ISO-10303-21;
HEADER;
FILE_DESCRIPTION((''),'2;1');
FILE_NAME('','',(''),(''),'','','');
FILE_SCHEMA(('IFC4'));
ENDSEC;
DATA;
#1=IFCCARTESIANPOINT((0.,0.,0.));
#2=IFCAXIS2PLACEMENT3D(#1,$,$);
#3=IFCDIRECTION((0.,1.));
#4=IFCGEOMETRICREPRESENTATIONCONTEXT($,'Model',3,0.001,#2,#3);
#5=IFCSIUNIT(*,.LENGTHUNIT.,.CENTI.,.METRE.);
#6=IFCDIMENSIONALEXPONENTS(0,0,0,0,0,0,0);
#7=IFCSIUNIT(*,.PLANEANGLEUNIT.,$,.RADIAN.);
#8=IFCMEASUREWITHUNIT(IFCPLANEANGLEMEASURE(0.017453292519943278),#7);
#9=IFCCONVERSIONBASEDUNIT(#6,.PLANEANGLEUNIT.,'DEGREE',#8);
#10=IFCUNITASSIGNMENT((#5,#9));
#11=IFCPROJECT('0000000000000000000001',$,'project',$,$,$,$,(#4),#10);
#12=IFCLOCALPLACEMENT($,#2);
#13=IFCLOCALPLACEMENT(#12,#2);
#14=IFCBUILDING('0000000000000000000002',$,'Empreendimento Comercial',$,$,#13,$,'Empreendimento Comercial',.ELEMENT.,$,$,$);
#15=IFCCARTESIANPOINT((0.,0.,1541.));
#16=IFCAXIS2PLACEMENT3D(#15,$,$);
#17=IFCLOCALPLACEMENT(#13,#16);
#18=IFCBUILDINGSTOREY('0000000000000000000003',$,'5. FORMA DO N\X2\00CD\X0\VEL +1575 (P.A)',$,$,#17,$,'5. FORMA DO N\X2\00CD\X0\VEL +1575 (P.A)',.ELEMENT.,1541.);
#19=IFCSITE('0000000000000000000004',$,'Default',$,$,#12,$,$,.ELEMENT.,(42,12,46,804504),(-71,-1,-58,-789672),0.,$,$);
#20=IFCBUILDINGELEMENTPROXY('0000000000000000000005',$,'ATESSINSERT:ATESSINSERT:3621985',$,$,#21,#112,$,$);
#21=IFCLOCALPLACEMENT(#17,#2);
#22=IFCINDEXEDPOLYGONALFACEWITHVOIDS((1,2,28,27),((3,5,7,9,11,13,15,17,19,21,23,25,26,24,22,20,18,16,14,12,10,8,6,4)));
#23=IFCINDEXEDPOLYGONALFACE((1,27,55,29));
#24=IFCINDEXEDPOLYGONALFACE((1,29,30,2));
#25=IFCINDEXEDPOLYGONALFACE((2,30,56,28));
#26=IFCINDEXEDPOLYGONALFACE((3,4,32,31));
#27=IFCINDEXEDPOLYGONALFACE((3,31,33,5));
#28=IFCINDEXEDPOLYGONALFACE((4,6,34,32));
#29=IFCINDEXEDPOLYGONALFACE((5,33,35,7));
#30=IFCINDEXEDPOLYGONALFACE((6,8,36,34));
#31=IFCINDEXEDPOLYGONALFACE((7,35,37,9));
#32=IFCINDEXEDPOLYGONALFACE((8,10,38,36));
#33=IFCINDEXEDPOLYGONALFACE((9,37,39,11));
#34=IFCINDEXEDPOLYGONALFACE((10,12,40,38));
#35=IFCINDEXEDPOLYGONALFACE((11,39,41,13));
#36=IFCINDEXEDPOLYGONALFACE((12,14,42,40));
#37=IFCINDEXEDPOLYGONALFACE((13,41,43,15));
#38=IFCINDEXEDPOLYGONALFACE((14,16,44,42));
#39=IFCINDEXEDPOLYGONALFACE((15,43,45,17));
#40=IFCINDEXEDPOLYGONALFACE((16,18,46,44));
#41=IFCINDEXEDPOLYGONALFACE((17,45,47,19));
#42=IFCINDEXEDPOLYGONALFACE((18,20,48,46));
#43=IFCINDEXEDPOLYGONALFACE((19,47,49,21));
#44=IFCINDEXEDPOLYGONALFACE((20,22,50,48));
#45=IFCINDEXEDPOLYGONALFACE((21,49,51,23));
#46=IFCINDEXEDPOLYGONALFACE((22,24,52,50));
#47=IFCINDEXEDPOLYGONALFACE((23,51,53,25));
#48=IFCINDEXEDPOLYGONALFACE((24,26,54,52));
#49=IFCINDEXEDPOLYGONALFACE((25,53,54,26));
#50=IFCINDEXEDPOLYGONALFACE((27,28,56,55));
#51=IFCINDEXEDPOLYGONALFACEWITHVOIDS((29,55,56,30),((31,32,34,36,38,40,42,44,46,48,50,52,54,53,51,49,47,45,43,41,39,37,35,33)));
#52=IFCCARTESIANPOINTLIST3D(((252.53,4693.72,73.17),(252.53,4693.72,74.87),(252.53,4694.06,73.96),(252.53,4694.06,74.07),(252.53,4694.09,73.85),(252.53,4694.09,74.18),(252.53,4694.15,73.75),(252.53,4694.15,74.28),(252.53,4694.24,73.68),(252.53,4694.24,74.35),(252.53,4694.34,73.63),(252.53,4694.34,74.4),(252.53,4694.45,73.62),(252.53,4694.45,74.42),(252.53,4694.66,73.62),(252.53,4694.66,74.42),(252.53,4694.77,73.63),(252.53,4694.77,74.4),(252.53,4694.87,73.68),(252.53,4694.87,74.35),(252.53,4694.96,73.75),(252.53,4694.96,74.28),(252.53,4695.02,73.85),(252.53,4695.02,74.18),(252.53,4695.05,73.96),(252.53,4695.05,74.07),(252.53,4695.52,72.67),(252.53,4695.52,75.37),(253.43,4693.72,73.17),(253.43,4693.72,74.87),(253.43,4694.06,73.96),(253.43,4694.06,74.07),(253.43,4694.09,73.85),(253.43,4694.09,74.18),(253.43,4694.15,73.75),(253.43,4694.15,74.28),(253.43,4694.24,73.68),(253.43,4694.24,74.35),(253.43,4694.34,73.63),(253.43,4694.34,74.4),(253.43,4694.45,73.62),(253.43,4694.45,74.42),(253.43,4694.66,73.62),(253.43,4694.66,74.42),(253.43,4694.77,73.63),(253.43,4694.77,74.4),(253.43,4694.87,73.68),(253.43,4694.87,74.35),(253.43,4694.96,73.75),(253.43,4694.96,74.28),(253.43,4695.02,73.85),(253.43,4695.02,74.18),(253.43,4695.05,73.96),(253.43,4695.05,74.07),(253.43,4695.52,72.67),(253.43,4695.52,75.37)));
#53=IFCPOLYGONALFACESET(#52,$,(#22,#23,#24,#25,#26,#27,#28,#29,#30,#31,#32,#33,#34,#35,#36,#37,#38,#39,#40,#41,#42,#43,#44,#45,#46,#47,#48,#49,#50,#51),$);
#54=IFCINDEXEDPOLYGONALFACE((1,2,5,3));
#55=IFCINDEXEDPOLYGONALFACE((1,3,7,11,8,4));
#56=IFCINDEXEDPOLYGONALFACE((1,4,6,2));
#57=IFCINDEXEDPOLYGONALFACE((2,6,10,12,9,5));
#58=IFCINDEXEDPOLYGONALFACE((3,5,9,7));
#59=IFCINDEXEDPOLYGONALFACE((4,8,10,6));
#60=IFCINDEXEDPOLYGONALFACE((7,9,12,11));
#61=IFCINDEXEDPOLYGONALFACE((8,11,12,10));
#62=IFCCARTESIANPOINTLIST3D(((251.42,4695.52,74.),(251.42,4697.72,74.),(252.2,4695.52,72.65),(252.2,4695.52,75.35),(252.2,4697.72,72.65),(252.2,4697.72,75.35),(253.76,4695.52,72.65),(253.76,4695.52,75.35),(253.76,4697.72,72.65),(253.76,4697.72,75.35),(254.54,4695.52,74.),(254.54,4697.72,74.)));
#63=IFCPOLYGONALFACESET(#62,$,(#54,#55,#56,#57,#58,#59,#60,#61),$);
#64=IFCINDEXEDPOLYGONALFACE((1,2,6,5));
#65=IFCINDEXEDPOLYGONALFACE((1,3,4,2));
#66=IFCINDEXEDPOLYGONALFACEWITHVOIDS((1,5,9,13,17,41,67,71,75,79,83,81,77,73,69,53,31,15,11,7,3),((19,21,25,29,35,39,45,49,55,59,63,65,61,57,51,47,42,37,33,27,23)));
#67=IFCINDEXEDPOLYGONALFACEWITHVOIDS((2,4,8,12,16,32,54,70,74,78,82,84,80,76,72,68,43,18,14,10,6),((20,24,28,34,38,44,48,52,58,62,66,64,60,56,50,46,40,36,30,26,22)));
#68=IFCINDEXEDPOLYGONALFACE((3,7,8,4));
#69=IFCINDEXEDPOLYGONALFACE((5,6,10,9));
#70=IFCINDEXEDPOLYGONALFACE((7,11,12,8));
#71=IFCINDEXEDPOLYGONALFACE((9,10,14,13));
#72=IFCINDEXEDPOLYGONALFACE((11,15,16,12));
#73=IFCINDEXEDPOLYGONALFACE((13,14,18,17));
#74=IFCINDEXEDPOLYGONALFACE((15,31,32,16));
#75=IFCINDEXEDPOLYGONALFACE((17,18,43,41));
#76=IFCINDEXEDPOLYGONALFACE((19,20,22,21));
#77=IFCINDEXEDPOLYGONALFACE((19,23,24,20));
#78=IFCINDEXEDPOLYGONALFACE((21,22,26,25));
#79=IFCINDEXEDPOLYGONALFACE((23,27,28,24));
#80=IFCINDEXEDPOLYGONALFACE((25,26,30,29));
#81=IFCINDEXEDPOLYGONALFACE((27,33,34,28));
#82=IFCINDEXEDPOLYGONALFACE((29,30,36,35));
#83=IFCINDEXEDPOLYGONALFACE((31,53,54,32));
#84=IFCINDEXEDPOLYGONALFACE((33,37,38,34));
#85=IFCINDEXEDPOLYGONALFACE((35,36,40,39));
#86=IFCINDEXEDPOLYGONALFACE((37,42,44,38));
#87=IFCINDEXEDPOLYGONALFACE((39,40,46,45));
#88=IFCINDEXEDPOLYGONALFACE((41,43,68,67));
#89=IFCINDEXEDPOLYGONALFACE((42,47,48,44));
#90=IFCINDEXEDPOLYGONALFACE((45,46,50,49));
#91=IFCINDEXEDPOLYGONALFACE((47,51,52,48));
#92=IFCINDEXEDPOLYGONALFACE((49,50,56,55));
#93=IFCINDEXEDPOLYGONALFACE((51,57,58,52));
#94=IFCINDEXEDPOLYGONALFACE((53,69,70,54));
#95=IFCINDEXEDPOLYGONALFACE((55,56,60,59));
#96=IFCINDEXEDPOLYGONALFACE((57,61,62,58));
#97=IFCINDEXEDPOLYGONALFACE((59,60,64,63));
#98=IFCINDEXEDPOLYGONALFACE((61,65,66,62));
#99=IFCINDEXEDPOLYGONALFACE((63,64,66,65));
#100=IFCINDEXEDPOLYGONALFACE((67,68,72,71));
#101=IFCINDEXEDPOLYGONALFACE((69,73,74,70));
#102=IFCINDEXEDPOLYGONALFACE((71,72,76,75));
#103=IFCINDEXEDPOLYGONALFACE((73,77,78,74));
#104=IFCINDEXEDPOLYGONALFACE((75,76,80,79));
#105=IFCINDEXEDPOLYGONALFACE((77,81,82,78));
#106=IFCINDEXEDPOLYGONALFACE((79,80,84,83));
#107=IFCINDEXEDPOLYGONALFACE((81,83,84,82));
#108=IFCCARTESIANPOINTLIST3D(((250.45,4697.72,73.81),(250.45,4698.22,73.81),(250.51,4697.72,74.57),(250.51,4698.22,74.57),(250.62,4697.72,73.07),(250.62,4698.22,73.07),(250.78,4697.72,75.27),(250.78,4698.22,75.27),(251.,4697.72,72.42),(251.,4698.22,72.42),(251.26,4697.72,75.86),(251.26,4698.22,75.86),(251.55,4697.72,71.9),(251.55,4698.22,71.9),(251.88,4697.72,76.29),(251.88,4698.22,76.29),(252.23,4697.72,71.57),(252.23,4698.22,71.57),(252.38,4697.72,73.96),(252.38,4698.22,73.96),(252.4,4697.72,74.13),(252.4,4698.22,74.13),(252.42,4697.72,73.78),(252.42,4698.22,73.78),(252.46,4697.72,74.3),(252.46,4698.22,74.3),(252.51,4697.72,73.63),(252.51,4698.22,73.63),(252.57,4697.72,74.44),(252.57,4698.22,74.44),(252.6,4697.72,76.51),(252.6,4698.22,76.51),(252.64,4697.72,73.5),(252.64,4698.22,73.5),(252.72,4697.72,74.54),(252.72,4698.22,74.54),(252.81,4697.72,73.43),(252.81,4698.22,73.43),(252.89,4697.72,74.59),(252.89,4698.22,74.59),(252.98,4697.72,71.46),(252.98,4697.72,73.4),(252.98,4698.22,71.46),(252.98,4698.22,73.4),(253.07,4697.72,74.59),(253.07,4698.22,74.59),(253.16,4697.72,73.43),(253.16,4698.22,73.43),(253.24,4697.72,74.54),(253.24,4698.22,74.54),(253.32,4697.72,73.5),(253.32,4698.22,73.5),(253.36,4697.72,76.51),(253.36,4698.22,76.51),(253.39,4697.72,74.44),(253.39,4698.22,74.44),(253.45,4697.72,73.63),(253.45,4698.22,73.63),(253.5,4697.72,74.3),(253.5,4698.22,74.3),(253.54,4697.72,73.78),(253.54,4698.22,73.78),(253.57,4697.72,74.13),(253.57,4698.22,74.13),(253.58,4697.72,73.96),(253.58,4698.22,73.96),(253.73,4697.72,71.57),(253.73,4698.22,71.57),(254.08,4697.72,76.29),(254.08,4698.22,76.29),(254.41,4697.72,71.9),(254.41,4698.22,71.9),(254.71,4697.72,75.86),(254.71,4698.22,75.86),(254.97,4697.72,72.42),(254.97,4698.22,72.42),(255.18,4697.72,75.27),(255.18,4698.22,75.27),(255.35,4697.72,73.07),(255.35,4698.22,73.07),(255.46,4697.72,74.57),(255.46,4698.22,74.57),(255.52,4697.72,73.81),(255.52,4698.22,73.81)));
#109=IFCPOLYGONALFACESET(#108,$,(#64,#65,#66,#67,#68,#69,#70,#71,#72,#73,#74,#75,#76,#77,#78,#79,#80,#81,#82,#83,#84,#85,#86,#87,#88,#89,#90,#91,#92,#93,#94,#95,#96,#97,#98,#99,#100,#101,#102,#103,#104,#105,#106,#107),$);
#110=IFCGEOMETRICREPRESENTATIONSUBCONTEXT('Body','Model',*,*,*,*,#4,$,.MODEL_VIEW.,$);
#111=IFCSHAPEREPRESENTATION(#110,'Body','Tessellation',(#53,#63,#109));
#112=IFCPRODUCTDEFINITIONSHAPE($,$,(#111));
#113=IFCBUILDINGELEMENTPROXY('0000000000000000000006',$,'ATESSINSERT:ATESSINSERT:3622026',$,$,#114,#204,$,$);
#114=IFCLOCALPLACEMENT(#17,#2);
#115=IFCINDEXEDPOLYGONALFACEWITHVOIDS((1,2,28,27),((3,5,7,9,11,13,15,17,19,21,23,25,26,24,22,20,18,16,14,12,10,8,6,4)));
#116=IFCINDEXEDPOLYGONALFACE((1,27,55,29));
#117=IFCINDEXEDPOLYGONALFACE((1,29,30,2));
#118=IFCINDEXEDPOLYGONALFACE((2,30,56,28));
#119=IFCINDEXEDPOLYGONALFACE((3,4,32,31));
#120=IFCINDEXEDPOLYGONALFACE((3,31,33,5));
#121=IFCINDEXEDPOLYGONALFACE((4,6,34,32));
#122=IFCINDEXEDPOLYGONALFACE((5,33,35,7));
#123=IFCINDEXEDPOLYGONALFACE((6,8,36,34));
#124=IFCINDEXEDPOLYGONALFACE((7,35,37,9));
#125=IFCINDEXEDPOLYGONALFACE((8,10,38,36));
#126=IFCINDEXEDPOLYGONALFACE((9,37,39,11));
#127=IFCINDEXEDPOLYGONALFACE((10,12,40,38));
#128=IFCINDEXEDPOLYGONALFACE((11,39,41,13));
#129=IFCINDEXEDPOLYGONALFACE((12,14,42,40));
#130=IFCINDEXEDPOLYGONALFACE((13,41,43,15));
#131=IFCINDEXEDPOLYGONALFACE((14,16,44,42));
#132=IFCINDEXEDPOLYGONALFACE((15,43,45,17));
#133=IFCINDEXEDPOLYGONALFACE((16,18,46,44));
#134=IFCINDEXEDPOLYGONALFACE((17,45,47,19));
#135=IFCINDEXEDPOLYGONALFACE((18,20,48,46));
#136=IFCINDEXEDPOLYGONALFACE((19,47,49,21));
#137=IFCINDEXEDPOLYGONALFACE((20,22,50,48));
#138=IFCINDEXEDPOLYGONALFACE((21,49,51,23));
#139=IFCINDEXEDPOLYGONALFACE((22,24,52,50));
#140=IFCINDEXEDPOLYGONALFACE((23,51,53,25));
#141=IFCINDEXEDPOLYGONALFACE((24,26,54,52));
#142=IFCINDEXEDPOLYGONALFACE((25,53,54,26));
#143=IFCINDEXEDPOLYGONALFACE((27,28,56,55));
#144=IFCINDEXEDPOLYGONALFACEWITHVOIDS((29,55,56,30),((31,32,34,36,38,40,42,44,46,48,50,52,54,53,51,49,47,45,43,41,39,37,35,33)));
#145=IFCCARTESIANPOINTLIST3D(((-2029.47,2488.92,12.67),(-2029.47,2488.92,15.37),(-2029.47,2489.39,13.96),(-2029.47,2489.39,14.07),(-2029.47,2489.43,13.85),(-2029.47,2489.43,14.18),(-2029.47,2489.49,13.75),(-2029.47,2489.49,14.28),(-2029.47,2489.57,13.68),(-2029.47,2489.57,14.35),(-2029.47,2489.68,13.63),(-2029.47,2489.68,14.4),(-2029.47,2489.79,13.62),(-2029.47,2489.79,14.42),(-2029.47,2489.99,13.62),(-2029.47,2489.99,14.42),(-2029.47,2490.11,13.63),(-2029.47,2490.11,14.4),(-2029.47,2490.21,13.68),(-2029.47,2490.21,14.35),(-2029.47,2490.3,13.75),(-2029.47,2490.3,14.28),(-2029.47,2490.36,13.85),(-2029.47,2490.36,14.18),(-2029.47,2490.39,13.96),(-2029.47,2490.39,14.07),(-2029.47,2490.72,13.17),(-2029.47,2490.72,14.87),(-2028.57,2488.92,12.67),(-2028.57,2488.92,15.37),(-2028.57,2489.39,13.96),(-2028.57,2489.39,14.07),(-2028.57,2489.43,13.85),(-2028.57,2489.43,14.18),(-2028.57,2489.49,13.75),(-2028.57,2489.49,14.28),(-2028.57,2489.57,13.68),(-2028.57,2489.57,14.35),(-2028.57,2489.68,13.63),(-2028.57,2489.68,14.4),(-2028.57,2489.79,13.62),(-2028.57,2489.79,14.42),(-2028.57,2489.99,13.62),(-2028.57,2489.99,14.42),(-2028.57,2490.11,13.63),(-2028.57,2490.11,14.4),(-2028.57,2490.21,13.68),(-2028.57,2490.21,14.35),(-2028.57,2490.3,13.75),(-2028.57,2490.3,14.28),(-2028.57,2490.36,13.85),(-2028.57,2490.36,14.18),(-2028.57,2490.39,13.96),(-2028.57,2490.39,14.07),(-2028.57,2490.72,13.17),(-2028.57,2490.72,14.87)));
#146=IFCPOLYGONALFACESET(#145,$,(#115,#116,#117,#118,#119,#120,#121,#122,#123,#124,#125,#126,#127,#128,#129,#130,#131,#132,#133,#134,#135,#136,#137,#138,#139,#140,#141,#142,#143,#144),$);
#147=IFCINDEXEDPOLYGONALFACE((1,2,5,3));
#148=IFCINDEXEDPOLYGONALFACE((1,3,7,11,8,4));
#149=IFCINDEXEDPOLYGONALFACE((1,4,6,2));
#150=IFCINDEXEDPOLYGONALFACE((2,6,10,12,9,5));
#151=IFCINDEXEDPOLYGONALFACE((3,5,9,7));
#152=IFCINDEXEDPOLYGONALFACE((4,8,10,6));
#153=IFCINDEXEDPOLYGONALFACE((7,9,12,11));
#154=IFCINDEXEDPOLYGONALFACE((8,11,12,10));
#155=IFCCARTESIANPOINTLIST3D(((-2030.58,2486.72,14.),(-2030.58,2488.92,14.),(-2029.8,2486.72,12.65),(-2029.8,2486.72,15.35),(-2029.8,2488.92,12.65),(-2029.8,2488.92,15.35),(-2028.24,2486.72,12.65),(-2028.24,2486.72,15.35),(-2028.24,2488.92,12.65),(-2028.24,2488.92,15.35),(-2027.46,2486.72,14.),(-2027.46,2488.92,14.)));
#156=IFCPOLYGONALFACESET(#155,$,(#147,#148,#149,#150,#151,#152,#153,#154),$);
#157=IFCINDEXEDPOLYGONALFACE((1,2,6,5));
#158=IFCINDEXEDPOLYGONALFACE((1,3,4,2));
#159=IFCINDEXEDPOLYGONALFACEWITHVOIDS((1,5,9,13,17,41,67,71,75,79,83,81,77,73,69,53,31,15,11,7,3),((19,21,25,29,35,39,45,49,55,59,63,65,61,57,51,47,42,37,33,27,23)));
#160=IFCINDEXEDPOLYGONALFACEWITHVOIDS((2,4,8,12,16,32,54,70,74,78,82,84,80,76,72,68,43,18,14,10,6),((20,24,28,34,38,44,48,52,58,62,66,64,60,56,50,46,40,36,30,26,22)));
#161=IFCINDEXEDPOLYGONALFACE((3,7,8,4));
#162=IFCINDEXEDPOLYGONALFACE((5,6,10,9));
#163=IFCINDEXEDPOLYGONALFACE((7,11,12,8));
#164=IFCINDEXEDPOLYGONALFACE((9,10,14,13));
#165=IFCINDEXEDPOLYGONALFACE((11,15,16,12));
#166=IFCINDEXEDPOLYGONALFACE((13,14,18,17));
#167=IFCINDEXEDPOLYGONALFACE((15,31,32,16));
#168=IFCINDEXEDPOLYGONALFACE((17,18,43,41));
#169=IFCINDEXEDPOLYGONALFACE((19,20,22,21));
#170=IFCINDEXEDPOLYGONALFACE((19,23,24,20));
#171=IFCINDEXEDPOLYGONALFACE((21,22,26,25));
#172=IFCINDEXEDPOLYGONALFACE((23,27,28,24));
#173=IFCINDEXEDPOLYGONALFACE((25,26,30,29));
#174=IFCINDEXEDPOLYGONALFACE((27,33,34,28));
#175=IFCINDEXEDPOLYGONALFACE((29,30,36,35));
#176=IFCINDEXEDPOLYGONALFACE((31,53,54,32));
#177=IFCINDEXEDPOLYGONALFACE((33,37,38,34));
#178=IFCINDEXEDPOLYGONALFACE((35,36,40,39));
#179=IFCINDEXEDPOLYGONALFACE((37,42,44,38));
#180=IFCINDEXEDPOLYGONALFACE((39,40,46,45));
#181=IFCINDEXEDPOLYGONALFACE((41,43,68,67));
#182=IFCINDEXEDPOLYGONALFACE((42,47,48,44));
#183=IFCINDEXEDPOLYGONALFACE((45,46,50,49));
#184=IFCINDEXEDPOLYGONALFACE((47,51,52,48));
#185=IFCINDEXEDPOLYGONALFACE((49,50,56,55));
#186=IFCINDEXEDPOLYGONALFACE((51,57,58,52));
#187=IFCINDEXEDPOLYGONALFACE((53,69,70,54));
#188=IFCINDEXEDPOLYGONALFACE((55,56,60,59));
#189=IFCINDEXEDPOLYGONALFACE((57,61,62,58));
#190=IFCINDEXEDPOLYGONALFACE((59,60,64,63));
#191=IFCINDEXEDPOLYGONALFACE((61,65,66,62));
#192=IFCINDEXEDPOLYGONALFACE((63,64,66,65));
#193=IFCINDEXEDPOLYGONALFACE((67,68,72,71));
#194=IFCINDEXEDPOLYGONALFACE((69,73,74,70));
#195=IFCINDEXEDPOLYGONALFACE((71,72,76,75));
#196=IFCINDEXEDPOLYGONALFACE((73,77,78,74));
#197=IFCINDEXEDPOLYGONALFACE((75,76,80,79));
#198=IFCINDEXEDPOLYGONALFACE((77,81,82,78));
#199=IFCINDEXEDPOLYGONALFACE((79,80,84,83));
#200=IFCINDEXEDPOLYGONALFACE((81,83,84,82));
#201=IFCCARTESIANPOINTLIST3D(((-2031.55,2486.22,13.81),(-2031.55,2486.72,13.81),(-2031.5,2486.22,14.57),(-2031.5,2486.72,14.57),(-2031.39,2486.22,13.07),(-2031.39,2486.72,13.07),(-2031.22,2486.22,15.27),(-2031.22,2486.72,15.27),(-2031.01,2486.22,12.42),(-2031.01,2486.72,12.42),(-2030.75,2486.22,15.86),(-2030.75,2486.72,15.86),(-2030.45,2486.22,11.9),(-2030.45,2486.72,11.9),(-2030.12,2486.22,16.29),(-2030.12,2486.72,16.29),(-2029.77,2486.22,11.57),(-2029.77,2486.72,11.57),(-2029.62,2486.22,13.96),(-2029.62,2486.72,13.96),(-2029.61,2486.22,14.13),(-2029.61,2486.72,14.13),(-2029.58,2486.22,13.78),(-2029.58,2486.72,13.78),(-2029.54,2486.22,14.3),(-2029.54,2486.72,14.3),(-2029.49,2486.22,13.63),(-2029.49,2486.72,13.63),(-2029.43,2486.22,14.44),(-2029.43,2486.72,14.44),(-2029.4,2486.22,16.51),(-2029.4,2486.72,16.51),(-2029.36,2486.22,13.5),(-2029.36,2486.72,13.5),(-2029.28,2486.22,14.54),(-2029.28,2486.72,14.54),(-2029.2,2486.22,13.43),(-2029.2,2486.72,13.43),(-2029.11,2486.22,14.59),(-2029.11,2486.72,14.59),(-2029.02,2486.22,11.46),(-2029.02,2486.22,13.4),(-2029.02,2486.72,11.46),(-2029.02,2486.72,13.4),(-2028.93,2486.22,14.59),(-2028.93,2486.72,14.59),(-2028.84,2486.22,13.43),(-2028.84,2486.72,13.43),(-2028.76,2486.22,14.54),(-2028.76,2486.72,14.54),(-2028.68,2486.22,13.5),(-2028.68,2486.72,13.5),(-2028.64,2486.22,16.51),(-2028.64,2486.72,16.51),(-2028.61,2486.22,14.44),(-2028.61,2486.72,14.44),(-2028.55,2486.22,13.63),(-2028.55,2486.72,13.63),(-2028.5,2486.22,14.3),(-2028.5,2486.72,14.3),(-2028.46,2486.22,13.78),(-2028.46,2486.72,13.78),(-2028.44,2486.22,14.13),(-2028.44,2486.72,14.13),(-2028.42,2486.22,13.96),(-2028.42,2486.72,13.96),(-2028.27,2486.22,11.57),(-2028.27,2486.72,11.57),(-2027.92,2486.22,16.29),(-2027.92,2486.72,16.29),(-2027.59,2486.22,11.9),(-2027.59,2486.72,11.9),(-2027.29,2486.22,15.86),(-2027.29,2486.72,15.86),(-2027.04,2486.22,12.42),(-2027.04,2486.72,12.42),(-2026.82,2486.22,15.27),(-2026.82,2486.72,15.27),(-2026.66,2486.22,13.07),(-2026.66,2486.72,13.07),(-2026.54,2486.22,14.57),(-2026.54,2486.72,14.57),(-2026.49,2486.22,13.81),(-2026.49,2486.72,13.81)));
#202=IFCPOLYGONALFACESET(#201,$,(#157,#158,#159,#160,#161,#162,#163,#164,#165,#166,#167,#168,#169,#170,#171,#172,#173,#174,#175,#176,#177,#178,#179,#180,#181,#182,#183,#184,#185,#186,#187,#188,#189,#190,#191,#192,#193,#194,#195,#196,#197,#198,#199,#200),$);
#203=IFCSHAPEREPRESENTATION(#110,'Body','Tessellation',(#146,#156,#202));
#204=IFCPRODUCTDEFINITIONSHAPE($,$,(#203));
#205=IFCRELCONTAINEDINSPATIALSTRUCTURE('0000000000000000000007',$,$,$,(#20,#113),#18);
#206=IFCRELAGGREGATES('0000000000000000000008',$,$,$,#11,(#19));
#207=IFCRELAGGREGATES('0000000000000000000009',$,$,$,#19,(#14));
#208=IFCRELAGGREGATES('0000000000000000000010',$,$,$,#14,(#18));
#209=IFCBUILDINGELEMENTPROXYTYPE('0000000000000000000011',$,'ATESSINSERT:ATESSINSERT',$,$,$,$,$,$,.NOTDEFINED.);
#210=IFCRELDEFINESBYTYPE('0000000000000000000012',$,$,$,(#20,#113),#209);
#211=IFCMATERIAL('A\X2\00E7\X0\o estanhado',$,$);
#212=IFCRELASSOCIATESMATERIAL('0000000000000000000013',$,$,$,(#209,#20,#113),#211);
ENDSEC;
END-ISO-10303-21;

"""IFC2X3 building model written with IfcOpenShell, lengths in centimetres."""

from ifc_helpers import new_model, entity, si_unit, converted_unit, direction, frame, frame_2d, origin, place, context, subcontext, project, spatial, polyline, circle_curve, parameter, trimmed, segment, composite_curve, hollow_circle, outline, extrude, source, transform, mapped, material, type_object, type_shapes, element, save


model = new_model("IFC2X3")

# Units and contexts
model_context = context("Model", 3, precision=0.001, world=origin(), true_north=direction((0.0, 1.0)))
body_context = subcontext(model_context, "Body", "Model", "MODEL_VIEW")
ifc_project = project(units=[si_unit("LENGTHUNIT", "METRE", prefix="CENTI"), converted_unit("PLANEANGLEUNIT", "DEGREE", entity("IfcPlaneAngleMeasure", 0.017453292519943278), si_unit("PLANEANGLEUNIT", "RADIAN"), dimensions=[0, 0, 0, 0, 0, 0, 0])], contexts=[model_context])

# Site, building, storey
site_placement = place(None, origin())
site = spatial("IfcSite", under=ifc_project, at=site_placement, Name="Default", CompositionType="ELEMENT", RefLatitude=(42, 12, 46, 804504), RefLongitude=(-71, -1, -58, -789672), RefElevation=0.0)
building_placement = place(site_placement, origin())
building = spatial("IfcBuilding", under=site, at=building_placement, Name="Empreendimento Comercial", LongName="Empreendimento Comercial", CompositionType="ELEMENT")
storey_placement = place(building_placement, frame((0.0, 0.0, 1541.0)))
storey = spatial("IfcBuildingStorey", under=building, at=storey_placement, Name="5. FORMA DO NÍVEL +1575 (P.A)", LongName="5. FORMA DO NÍVEL +1575 (P.A)", CompositionType="ELEMENT", Elevation=1541.0)

# Building element proxies
ifc_material_1 = material(Name="Aço estanhado")
building_element_proxy_type_1 = type_object("IfcBuildingElementProxyType", Name="ATESSINSERT:ATESSINSERT", PredefinedType="NOTDEFINED", material=ifc_material_1)
shared_shape_1 = source(origin(), body_context, "Body", "SweptSolid", [
    extrude(outline(polyline([(-1.35, -0.9), (1.35, -0.9), (0.85, 0.9), (-0.85, 0.9), (-1.35, -0.9)]), holes=[composite_curve([segment(trimmed(circle_curve(frame_2d((0.0, 0.17), x_axis=(1.0, 0.0)), 0.4), [parameter(0.0)], [parameter(180.0)], True, "PARAMETER"), False, "CONTINUOUS"), segment(polyline([(0.4, 0.17), (0.4, -0.03)]), True, "CONTINUOUS"), segment(trimmed(circle_curve(frame_2d((0.0, -0.03), x_axis=(1.0, 0.0)), 0.4), [parameter(180.0)], [parameter(0.0)], True, "PARAMETER"), False, "CONTINUOUS"), segment(polyline([(-0.4, -0.03), (-0.4, 0.17)]), True, "CONTINUOUS")], self_intersect=False)]), frame((-1.4, -0.45, 30.02), z_axis=(0.0, 1.0, 0.0), x_axis=(0.0, 0.0, 1.0)), (0.0, 0.0, 1.0), 0.9),
    extrude(outline(polyline([(-0.78, -1.35), (0.78, -1.35), (1.56, 0.0), (0.78, 1.35), (-0.78, 1.35), (-1.56, 0.0), (-0.78, -1.35)])), frame((-4.5, 0.0, 30.0), z_axis=(1.0, 0.0, 0.0), x_axis=(0.0, 0.5, 0.866025)), (0.0, 0.0, 1.0), 2.2),
    extrude(hollow_circle(Radius=2.54, WallThickness=1.94, at=frame_2d((0.0, 0.0), x_axis=(1.0, 0.0))), frame((-5.0, 0.0, 30.0), z_axis=(1.0, 0.0, 0.0), x_axis=(0.0, 0.0, -1.0)), (0.0, 0.0, 1.0), 0.5),
])
type_shapes(building_element_proxy_type_1, [shared_shape_1])
for number, where, z_axis, x_axis, name in (
    (1, (252.98, 4693.22, 44.0), (0.0, 0.0, 1.0), (0.0, -1.0, 0.0), "ATESSINSERT:ATESSINSERT:3621985"),
    (2, (-2029.02, 2491.22, -16.0), (0.0, 0.0, 1.0), (0.0, 1.0, 0.0), "ATESSINSERT:ATESSINSERT:3622026"),
):
    element("IfcBuildingElementProxy", number, at=place(storey_placement, frame(where, z_axis=z_axis, x_axis=x_axis)), inside=storey, type_object=building_element_proxy_type_1, material=ifc_material_1, Name=name, context=body_context, shape_type="MappedRepresentation", body=[
        mapped(shared_shape_1, transform((0.0, 0.0, 0.0), scale=1.0)),
    ])

save(model, "model.ifc")
